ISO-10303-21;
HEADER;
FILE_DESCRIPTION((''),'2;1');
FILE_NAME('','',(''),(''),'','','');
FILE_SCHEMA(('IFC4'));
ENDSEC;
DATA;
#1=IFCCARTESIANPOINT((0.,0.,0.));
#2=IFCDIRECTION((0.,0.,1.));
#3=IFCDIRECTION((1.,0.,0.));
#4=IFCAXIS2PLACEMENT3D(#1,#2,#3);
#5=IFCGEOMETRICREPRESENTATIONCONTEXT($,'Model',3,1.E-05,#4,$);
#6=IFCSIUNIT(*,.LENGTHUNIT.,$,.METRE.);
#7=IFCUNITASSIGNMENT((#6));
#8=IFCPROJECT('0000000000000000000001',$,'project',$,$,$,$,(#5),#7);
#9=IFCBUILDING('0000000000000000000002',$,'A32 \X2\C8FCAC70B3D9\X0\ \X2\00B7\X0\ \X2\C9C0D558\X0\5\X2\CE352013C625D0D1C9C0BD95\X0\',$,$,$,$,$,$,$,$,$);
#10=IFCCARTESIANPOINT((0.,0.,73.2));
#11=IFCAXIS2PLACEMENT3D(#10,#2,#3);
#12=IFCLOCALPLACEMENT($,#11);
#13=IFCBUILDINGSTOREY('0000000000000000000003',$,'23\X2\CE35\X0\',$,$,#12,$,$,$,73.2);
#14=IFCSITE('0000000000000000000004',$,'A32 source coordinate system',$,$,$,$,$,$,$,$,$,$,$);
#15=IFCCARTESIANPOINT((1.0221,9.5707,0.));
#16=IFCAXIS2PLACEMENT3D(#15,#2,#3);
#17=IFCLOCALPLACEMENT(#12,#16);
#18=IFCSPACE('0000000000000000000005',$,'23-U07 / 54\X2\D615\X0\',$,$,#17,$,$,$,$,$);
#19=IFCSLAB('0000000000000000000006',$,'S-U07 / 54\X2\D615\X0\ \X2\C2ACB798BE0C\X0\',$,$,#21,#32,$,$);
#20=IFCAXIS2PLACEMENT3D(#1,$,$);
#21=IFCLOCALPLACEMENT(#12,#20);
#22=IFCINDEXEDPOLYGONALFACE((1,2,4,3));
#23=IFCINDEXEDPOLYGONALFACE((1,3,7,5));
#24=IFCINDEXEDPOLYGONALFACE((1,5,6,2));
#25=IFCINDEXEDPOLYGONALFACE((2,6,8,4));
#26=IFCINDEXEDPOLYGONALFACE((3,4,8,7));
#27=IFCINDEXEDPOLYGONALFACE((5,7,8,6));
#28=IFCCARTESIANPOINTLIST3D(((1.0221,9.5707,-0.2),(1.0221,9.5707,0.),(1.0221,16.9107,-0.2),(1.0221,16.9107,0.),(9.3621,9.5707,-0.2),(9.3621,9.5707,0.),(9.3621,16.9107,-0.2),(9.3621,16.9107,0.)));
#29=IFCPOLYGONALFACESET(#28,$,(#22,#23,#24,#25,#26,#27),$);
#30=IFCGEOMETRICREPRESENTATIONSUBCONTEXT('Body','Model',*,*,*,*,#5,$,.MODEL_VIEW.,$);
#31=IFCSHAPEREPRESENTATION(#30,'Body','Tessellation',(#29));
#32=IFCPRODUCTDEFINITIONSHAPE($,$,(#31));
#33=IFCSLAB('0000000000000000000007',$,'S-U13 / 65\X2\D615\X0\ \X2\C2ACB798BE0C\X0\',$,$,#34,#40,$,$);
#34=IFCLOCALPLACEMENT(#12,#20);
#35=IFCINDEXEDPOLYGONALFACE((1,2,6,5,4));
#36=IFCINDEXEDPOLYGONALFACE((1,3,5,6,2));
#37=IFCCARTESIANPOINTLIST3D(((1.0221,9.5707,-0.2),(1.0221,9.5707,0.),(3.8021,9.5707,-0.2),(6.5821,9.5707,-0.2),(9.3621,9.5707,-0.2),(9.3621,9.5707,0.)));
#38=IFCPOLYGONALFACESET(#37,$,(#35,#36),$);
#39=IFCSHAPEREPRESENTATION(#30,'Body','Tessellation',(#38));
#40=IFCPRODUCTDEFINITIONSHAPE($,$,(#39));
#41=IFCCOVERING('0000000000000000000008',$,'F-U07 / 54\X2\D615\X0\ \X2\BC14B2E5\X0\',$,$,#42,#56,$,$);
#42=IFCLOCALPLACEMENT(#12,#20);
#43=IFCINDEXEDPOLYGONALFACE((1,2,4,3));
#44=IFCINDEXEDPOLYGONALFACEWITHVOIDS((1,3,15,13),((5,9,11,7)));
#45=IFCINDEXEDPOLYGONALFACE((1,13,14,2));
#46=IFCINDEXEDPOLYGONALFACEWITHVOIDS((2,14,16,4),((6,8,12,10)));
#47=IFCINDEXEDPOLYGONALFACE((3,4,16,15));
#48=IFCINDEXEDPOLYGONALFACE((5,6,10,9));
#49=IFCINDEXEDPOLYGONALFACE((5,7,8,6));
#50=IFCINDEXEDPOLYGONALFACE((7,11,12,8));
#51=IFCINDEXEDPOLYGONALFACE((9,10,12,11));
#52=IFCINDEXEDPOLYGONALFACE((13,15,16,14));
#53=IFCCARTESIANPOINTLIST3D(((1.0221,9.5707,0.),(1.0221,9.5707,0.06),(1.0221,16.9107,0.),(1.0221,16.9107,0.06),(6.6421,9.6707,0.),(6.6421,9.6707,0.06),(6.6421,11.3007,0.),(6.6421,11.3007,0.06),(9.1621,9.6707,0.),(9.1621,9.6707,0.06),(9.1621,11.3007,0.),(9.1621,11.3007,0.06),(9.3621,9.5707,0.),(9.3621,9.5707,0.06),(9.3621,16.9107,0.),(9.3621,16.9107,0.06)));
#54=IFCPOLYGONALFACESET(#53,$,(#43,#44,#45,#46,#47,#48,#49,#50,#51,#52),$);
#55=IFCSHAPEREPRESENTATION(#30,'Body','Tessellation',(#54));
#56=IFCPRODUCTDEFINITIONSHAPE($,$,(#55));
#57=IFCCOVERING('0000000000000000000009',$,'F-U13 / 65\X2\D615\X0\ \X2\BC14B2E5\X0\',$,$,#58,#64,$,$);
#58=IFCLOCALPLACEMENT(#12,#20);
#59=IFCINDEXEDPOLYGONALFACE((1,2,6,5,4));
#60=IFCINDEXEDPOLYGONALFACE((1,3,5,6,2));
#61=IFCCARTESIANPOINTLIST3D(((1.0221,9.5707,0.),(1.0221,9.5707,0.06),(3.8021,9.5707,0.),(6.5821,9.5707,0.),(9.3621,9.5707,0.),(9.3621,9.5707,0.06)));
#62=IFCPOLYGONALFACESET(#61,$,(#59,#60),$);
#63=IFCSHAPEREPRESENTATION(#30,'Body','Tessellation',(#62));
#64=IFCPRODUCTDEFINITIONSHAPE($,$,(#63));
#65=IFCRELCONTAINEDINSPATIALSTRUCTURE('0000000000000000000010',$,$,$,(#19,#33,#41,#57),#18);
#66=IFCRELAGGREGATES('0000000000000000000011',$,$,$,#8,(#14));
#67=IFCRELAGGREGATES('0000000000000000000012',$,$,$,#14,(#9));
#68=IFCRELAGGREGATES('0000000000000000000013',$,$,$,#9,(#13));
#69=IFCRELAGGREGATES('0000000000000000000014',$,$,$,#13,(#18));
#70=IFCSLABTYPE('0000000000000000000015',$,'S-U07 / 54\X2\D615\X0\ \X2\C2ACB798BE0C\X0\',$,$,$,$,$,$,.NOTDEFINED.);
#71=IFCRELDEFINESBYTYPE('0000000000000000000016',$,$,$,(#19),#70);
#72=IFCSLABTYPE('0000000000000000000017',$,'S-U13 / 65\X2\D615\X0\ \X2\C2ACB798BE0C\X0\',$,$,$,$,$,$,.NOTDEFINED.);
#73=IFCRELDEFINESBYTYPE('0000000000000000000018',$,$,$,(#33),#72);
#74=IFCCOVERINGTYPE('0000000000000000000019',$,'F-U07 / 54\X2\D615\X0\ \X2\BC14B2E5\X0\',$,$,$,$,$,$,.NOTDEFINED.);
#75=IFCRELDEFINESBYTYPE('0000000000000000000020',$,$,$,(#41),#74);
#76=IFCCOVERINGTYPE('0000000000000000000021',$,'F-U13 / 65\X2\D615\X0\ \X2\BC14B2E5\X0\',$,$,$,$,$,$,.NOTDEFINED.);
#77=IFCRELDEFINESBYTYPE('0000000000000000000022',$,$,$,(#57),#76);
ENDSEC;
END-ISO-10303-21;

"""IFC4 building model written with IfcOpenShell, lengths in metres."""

from ifc_helpers import new_model, si_unit, frame, origin, origin_with_axes, place, context, subcontext, project, spatial, polyline, outline, extrude, source, transform, mapped, type_object, type_shapes, element, save


model = new_model("IFC4")

# Units and contexts
model_context = context("Model", 3, precision=1e-05, world=origin_with_axes())
body_context = subcontext(model_context, "Body", "Model", "MODEL_VIEW")
ifc_project = project(units=[si_unit("LENGTHUNIT", "METRE")], contexts=[model_context])

# Site, building, storey, space
storey_placement = place(None, frame((0.0, 0.0, 73.2), z_axis=(0.0, 0.0, 1.0), x_axis=(1.0, 0.0, 0.0)))
space_placement = place(storey_placement, frame((1.0221, 9.5707, 0.0), z_axis=(0.0, 0.0, 1.0), x_axis=(1.0, 0.0, 0.0)))
site = spatial("IfcSite", under=ifc_project, Name="A32 source coordinate system")
building = spatial("IfcBuilding", under=site, Name="A32 주거동 · 지하5층–옥탑지붕")
storey = spatial("IfcBuildingStorey", under=building, at=storey_placement, Name="23층", Elevation=73.2)
space = spatial("IfcSpace", under=storey, at=space_placement, Name="23-U07 / 54형")

# Slabs
slab_type_1 = type_object("IfcSlabType", Name="S-U07 / 54형 슬래브", PredefinedType="NOTDEFINED")
shared_shape_1 = source(origin(), body_context, "Body", "SweptSolid", [
    extrude(outline(polyline([(0.0, 0.0), (0.0, 7.34), (8.34, 7.34), (8.34, 0.0), (0.0, 0.0)])), frame((0.0, 0.0, -0.2)), (0.0, 0.0, 1.0), 0.2),
])
type_shapes(slab_type_1, [shared_shape_1])
slab_1_placement = place(space_placement, origin_with_axes())
element("IfcSlab", 1, at=slab_1_placement, inside=space, type_object=slab_type_1, Name="S-U07 / 54형 슬래브", context=body_context, shape_type="MappedRepresentation", body=[
    mapped(shared_shape_1, transform((0.0, 0.0, 0.0), scale=1.0)),
])
slab_type_2 = type_object("IfcSlabType", Name="S-U13 / 65형 슬래브", PredefinedType="NOTDEFINED")
shared_shape_2 = source(origin(), body_context, "Body", "SweptSolid", [
    extrude(outline(polyline([(0.0, 0.0), (8.34, 0.0), (8.34, 0.0), (0.0, 0.0), (0.0, 0.0)])), frame((0.0, 0.0, -0.2)), (0.0, 0.0, 1.0), 0.2),
])
type_shapes(slab_type_2, [shared_shape_2])
slab_2_placement = place(space_placement, origin_with_axes())
element("IfcSlab", 2, at=slab_2_placement, inside=space, type_object=slab_type_2, Name="S-U13 / 65형 슬래브", context=body_context, shape_type="MappedRepresentation", body=[
    mapped(shared_shape_2, transform((0.0, 0.0, 0.0), scale=1.0)),
])

# Coverings
covering_type_1 = type_object("IfcCoveringType", Name="F-U07 / 54형 바닥", PredefinedType="NOTDEFINED")
shared_shape_3 = source(origin(), body_context, "Body", "SweptSolid", [
    extrude(outline(polyline([(0.0, 0.0), (0.0, 7.34), (8.34, 7.34), (8.34, 0.0), (0.0, 0.0)]), holes=[polyline([(5.62, 1.73), (5.62, 0.1), (8.14, 0.1), (8.14, 1.73), (5.62, 1.73)])]), origin(), (0.0, 0.0, 1.0), 0.06),
])
type_shapes(covering_type_1, [shared_shape_3])
covering_1_placement = place(space_placement, origin_with_axes())
element("IfcCovering", 3, at=covering_1_placement, inside=space, type_object=covering_type_1, Name="F-U07 / 54형 바닥", context=body_context, shape_type="MappedRepresentation", body=[
    mapped(shared_shape_3, transform((0.0, 0.0, 0.0), scale=1.0)),
])
covering_type_2 = type_object("IfcCoveringType", Name="F-U13 / 65형 바닥", PredefinedType="NOTDEFINED")
shared_shape_4 = source(origin(), body_context, "Body", "SweptSolid", [
    extrude(outline(polyline([(0.0, 0.0), (8.34, 0.0), (8.34, 0.0), (0.0, 0.0), (0.0, 0.0)])), origin(), (0.0, 0.0, 1.0), 0.06),
])
type_shapes(covering_type_2, [shared_shape_4])
covering_2_placement = place(space_placement, origin_with_axes())
element("IfcCovering", 4, at=covering_2_placement, inside=space, type_object=covering_type_2, Name="F-U13 / 65형 바닥", context=body_context, shape_type="MappedRepresentation", body=[
    mapped(shared_shape_4, transform((0.0, 0.0, 0.0), scale=1.0)),
])

save(model, "model.ifc")
